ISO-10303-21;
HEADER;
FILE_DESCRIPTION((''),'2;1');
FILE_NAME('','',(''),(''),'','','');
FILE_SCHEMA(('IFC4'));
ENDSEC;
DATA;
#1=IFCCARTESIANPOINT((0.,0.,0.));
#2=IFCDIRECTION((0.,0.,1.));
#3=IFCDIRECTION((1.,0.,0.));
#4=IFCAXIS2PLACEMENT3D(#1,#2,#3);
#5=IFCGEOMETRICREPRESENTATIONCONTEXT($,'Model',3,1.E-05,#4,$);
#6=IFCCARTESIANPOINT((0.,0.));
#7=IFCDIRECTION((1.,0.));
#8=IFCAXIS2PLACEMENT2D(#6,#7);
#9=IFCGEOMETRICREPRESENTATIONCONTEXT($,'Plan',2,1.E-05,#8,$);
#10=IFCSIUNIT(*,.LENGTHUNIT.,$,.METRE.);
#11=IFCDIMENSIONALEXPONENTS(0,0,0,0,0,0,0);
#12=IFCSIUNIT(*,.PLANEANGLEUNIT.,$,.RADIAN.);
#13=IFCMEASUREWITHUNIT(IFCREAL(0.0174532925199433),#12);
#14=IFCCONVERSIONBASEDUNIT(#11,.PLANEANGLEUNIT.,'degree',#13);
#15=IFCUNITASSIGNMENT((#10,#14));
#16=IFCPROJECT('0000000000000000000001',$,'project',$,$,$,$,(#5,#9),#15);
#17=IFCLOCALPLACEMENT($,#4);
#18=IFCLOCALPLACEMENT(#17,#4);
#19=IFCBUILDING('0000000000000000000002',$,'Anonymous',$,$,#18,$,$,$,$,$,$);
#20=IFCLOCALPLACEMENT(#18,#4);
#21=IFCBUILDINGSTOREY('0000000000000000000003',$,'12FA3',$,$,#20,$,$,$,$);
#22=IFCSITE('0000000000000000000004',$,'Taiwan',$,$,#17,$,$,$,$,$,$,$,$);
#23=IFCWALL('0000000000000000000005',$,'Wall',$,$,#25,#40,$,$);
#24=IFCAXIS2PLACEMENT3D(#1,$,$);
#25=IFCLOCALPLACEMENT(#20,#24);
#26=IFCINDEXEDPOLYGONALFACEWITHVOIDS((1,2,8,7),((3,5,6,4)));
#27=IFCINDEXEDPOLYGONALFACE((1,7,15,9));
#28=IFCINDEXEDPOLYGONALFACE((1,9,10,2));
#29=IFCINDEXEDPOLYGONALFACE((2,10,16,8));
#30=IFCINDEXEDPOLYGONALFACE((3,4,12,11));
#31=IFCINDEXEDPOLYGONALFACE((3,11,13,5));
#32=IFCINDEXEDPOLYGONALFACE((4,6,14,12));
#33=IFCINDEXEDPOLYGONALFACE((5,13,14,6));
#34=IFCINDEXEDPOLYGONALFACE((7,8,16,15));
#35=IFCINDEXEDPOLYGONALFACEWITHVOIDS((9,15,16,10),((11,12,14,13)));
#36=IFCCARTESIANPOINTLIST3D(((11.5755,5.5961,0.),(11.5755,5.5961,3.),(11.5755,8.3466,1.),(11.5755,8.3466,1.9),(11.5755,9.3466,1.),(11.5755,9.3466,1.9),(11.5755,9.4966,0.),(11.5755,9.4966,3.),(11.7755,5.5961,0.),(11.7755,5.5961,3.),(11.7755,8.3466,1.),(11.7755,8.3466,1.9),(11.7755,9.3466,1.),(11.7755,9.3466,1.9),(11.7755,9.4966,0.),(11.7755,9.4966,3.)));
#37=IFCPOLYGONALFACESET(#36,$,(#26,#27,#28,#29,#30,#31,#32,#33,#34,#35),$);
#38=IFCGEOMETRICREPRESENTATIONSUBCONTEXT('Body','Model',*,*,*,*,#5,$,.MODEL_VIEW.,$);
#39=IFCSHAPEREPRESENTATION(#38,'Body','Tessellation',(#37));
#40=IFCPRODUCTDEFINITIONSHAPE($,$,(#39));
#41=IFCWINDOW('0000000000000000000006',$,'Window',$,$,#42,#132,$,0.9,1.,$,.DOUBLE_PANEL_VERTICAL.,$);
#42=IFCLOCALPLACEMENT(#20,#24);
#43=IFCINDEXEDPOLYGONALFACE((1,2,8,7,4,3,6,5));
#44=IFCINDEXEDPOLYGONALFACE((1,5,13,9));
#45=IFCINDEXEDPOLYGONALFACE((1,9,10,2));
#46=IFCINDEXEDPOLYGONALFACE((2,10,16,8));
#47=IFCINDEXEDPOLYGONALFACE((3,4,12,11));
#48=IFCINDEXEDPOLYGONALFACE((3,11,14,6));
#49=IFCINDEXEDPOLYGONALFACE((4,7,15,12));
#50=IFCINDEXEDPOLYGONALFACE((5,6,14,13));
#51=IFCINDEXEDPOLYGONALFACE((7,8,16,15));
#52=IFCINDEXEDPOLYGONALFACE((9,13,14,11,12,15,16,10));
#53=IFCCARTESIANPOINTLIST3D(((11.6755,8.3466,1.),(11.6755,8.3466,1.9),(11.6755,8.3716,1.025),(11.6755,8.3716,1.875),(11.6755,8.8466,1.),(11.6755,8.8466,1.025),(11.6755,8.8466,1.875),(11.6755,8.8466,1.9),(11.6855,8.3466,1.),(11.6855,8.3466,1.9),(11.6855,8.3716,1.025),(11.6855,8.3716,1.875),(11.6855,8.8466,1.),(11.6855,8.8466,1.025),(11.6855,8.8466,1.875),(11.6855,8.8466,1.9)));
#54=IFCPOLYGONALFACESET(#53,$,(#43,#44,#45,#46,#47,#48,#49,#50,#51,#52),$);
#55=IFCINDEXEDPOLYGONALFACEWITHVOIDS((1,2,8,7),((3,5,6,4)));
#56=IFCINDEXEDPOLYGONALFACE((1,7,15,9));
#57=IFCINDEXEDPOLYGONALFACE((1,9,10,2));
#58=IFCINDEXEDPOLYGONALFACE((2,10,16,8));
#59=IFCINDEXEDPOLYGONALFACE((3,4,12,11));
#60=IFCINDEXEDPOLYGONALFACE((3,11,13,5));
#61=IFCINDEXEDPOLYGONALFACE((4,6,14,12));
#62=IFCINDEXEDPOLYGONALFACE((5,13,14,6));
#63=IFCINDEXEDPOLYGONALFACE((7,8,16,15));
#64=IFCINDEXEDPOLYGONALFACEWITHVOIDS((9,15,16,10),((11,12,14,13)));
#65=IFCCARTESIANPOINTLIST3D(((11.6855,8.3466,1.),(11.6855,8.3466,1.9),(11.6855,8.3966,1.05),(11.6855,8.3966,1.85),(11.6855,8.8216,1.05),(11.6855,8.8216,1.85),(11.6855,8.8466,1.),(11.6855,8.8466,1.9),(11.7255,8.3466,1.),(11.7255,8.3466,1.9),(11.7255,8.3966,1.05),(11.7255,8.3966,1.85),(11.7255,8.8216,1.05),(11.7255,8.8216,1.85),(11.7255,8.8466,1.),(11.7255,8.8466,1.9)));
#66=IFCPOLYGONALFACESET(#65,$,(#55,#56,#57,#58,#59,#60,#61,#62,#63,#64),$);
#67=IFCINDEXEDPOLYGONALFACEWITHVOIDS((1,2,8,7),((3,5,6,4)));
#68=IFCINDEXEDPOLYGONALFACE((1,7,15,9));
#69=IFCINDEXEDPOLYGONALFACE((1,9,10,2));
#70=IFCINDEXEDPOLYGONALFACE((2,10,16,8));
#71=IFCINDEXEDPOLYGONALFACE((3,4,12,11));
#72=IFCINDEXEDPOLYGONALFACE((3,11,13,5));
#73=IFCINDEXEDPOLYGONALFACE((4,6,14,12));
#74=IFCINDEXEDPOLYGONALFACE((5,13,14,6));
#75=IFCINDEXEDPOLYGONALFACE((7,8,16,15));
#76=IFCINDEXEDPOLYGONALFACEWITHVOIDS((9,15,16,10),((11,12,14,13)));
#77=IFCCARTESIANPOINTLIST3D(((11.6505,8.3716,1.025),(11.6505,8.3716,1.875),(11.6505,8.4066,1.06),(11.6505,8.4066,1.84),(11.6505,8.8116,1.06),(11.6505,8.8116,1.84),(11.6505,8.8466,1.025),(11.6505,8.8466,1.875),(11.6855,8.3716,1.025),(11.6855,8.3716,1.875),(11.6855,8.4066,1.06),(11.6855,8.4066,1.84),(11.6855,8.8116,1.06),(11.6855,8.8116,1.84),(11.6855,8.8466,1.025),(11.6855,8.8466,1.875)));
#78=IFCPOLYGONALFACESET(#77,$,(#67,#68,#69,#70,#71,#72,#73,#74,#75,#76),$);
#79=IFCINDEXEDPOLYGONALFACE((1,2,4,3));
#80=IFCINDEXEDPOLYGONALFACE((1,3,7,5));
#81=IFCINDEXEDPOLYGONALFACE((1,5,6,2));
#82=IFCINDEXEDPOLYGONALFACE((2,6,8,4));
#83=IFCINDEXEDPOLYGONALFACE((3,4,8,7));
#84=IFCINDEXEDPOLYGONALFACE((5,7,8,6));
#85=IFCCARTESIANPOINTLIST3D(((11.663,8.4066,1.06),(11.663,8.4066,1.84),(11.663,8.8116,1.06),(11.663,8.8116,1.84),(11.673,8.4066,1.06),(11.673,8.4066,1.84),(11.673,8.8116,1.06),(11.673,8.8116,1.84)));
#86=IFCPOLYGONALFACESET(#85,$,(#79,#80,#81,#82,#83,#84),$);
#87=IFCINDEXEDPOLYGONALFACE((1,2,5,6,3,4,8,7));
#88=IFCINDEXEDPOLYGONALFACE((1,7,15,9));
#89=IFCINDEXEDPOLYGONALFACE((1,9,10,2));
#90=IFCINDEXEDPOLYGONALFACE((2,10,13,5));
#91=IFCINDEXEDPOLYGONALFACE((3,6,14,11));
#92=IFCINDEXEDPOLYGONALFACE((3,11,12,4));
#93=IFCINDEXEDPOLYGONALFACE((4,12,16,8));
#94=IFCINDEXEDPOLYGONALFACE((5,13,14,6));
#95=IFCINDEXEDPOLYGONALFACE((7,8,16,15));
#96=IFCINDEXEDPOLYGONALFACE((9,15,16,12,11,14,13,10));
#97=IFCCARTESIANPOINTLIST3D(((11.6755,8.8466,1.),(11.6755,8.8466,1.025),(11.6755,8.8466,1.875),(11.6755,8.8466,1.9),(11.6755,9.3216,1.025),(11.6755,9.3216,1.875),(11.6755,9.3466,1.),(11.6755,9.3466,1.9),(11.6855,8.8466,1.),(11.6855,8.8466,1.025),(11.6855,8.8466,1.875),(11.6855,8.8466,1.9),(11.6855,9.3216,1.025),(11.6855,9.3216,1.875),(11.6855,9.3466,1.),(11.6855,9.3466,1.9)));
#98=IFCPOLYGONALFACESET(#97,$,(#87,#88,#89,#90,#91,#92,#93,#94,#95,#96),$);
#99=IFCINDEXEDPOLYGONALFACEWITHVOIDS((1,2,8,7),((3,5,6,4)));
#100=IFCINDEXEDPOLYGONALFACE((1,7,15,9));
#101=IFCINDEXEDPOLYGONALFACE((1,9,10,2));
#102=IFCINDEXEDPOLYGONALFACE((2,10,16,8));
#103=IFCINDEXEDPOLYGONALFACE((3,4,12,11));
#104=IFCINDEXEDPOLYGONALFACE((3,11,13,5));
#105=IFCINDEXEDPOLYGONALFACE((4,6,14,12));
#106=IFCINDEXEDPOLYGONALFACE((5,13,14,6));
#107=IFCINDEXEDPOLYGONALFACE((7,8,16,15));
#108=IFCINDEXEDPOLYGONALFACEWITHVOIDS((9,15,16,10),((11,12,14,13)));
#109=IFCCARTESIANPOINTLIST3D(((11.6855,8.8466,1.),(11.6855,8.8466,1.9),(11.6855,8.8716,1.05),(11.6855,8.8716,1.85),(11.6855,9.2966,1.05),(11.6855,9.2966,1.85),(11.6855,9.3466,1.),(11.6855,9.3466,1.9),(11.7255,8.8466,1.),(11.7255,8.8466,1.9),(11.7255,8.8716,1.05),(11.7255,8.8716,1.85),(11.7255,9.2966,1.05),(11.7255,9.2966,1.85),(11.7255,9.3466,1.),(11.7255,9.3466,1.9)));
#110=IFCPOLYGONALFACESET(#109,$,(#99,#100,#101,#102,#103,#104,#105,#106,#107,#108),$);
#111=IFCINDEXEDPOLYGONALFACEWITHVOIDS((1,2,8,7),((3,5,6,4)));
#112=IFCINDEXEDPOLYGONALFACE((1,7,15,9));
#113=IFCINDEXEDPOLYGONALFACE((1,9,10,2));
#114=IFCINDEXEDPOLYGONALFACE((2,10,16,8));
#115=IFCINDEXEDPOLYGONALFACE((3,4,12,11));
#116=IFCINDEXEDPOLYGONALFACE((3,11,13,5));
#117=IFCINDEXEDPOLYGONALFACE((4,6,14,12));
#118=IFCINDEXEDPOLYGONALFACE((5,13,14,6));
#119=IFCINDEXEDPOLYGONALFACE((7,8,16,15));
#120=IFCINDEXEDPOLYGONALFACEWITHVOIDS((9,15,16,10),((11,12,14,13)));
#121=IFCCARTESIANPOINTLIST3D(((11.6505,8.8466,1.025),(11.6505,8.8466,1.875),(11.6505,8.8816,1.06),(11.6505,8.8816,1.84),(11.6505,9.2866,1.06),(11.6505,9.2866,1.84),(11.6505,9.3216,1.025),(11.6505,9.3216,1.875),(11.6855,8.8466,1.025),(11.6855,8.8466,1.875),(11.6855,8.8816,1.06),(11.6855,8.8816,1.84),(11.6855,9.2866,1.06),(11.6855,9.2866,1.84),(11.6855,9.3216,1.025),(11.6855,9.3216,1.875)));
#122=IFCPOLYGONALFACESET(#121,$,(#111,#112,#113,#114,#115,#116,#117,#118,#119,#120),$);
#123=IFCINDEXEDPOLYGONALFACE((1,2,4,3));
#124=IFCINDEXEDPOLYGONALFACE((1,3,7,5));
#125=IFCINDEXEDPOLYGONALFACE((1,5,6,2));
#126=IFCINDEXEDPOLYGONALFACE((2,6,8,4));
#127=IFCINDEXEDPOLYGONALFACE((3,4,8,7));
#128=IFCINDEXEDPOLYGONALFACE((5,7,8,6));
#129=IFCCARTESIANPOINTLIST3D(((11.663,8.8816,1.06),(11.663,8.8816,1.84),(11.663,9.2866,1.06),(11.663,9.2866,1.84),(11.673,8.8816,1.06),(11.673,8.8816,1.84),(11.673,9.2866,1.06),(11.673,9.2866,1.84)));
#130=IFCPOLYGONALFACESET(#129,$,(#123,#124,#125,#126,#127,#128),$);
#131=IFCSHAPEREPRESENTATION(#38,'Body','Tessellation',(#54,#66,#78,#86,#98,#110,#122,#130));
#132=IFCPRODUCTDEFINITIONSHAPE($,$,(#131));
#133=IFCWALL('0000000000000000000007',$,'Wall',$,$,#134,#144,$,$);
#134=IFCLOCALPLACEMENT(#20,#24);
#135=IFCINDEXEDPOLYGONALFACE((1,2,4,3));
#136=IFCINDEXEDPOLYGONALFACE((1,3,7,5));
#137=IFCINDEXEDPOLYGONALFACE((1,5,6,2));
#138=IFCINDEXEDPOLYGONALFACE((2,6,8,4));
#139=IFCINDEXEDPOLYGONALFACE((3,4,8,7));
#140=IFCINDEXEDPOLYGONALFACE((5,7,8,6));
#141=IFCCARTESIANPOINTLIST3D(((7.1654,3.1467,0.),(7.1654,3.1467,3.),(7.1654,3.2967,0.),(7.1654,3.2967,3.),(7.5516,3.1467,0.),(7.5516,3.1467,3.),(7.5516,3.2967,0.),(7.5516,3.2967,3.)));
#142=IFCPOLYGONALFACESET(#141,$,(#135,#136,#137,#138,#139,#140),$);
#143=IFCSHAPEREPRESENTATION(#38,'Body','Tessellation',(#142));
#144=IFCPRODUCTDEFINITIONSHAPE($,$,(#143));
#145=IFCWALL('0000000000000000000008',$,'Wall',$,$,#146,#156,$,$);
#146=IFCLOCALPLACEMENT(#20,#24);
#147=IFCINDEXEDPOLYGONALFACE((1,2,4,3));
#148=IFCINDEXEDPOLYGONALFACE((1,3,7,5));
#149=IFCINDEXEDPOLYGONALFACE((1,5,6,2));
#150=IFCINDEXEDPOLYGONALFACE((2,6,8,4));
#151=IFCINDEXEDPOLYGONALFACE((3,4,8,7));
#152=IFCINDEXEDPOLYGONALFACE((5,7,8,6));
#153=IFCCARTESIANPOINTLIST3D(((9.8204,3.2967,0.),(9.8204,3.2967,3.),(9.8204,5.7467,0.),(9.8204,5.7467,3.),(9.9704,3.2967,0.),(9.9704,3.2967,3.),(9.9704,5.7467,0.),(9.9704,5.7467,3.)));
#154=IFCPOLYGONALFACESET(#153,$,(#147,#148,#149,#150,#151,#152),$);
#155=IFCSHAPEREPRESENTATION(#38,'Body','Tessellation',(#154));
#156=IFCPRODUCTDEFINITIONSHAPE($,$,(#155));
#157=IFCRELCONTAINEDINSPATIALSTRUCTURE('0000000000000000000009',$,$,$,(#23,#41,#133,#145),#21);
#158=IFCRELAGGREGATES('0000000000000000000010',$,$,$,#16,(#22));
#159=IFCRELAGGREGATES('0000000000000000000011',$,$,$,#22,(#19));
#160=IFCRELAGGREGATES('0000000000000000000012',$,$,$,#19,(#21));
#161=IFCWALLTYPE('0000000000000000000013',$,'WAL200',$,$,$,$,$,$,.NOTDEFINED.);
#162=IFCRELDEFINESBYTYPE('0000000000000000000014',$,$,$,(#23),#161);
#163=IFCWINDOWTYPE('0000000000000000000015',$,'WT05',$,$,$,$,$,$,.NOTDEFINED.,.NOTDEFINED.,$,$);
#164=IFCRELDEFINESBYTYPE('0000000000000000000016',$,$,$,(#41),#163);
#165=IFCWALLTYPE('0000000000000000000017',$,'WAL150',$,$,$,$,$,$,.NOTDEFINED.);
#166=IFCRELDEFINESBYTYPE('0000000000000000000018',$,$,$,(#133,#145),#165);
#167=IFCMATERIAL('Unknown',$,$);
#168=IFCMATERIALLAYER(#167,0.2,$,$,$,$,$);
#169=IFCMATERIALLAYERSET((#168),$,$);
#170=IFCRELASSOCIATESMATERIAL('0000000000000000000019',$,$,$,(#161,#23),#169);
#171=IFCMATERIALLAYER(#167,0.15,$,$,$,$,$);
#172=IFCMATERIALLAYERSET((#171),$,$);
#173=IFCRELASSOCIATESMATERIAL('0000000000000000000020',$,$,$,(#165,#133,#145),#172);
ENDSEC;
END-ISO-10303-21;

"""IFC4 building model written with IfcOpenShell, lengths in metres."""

from ifc_helpers import new_model, entity, si_unit, converted_unit, frame, origin_with_axes, origin_2d_with_axis, place, context, subcontext, project, spatial, line, indexed_curve, outline, extrude, shape, source, transform, mapped, material, layer, layer_set, layer_usage, type_object, type_shapes, element, fill, save


model = new_model("IFC4")

# Units and contexts
model_context = context("Model", 3, precision=1e-05, world=origin_with_axes())
plan_context = context("Plan", 2, precision=1e-05, world=origin_2d_with_axis())
body_context_1 = subcontext(model_context, "Body", "Model", "MODEL_VIEW")
body_context_2 = subcontext(plan_context, "Body", "Plan", "PLAN_VIEW")
ifc_project = project(units=[si_unit("LENGTHUNIT", "METRE"), converted_unit("PLANEANGLEUNIT", "degree", entity("IfcReal", 0.0174532925199433), si_unit("PLANEANGLEUNIT", "RADIAN"), dimensions=[0, 0, 0, 0, 0, 0, 0])], contexts=[model_context, plan_context])

# Site, building, storey
site_placement = place(None, origin_with_axes())
site = spatial("IfcSite", under=ifc_project, at=site_placement, Name="Taiwan")
building_placement = place(site_placement, origin_with_axes())
building = spatial("IfcBuilding", under=site, at=building_placement, Name="Anonymous")
storey_placement = place(building_placement, origin_with_axes())
storey = spatial("IfcBuildingStorey", under=building, at=storey_placement, Name="12FA3")

# Shared definitions
ifc_material = material(Name="Unknown")

# Wall, opening, window
ifc_layer_1 = layer(ifc_material, 0.2)
ifc_layer_set_1 = layer_set([ifc_layer_1])
ifc_layer_usage_1 = layer_usage(ifc_layer_set_1, "AXIS2", "POSITIVE", 0.0)
wall_type_1 = type_object("IfcWallType", Name="WAL200", PredefinedType="NOTDEFINED", material=ifc_layer_set_1)
wall_1_placement = place(storey_placement, frame((11.7755, 5.5961, 0.0), z_axis=(0.0, 0.0, 1.0), x_axis=(0.0, 1.0, 0.0)))
wall_1 = element("IfcWall", 1, at=wall_1_placement, inside=storey, type_object=wall_type_1, material=ifc_layer_usage_1, Name="Wall", context=body_context_1, shape_type="SweptSolid", body=[
    extrude(outline(indexed_curve([(0.0, 0.0), (0.0, 0.2), (3.9005, 0.2), (3.9005, 0.0)], segments=[line(1, 2, 3, 4, 1)])), origin_with_axes(), (0.0, 0.0, 1.0), 3.0),
])
shared_shape_1 = source(origin_with_axes(), body_context_1, "Body", "SweptSolid", [
    extrude(outline(indexed_curve([(0.0, 0.0), (1.0, 0.0), (1.0, 0.9), (0.0, 0.9)], segments=[line(1, 2, 3, 4, 1)])), frame((0.0, -0.6, 0.0), z_axis=(0.0, -1.0, 0.0), x_axis=(1.0, 0.0, 0.0)), (0.0, 0.0, -1.0), 1.2),
])
opening_1_placement = place(wall_1_placement, frame((2.7505, 0.0, 1.0), z_axis=(0.0, 0.0, 1.0), x_axis=(1.0, 0.0, 0.0)))
opening_1 = element("IfcOpeningElement", 2, at=opening_1_placement, cuts=wall_1, PredefinedType="OPENING", context=body_context_1, shape_type="MappedRepresentation", body=[
    mapped(shared_shape_1, transform((0.0, 0.0, 0.0), x_axis=(1.0, 0.0, 0.0), y_axis=(0.0, 1.0, 0.0), z_axis=(0.0, 0.0, 1.0), scale=1.0)),
])
window_type_1 = type_object("IfcWindowType", Name="WT05", PartitioningType="NOTDEFINED", PredefinedType="NOTDEFINED")
shared_shape_2 = source(origin_with_axes(), body_context_1, "Body", "SweptSolid", [
    extrude(outline(indexed_curve([(0.5, 0.0), (0.0, 0.0), (0.0, 0.9), (0.5, 0.9), (0.5, 0.875), (0.025, 0.875), (0.025, 0.025), (0.5, 0.025)], segments=[line(1, 2, 3, 4, 5, 6, 7, 8, 1)])), frame((0.0, 0.09, 0.0), z_axis=(0.0, -1.0, 0.0), x_axis=(1.0, 0.0, 0.0)), (0.0, 0.0, -1.0), 0.01),
    extrude(outline(indexed_curve([(0.0, 0.0), (0.5, 0.0), (0.5, 0.9), (0.0, 0.9)], segments=[line(1, 2, 3, 4, 1)]), holes=[indexed_curve([(0.05, 0.05), (0.475, 0.05), (0.475, 0.85), (0.05, 0.85)], segments=[line(1, 2, 3, 4, 1)])]), frame((0.0, 0.05, 0.0), z_axis=(0.0, -1.0, 0.0), x_axis=(1.0, 0.0, 0.0)), (0.0, 0.0, -1.0), 0.04),
    extrude(outline(indexed_curve([(0.0, 0.0), (0.475, 0.0), (0.475, 0.85), (0.0, 0.85)], segments=[line(1, 2, 3, 4, 1)]), holes=[indexed_curve([(0.035, 0.035), (0.44, 0.035), (0.44, 0.815), (0.035, 0.815)], segments=[line(1, 2, 3, 4, 1)])]), frame((0.025, 0.09, 0.025), z_axis=(0.0, -1.0, 0.0), x_axis=(1.0, 0.0, 0.0)), (0.0, 0.0, -1.0), 0.035),
    extrude(outline(indexed_curve([(0.035, 0.035), (0.44, 0.035), (0.44, 0.815), (0.035, 0.815)], segments=[line(1, 2, 3, 4, 1)])), frame((0.025, 0.1025, 0.025), z_axis=(0.0, -1.0, 0.0), x_axis=(1.0, 0.0, 0.0)), (0.0, 0.0, -1.0), 0.01),
    extrude(outline(indexed_curve([(0.0, 0.9), (0.5, 0.9), (0.5, 0.0), (0.0, 0.0), (0.0, 0.025), (0.475, 0.025), (0.475, 0.875), (0.0, 0.875)], segments=[line(1, 2, 3, 4, 5, 6, 7, 8, 1)])), frame((0.5, 0.09, 0.0), z_axis=(0.0, -1.0, 0.0), x_axis=(1.0, 0.0, 0.0)), (0.0, 0.0, -1.0), 0.01),
    extrude(outline(indexed_curve([(0.0, 0.0), (0.5, 0.0), (0.5, 0.9), (0.0, 0.9)], segments=[line(1, 2, 3, 4, 1)]), holes=[indexed_curve([(0.025, 0.05), (0.45, 0.05), (0.45, 0.85), (0.025, 0.85)], segments=[line(1, 2, 3, 4, 1)])]), frame((0.5, 0.05, 0.0), z_axis=(0.0, -1.0, 0.0), x_axis=(1.0, 0.0, 0.0)), (0.0, 0.0, -1.0), 0.04),
    extrude(outline(indexed_curve([(0.0, 0.0), (0.475, 0.0), (0.475, 0.85), (0.0, 0.85)], segments=[line(1, 2, 3, 4, 1)]), holes=[indexed_curve([(0.035, 0.035), (0.44, 0.035), (0.44, 0.815), (0.035, 0.815)], segments=[line(1, 2, 3, 4, 1)])]), frame((0.5, 0.09, 0.025), z_axis=(0.0, -1.0, 0.0), x_axis=(1.0, 0.0, 0.0)), (0.0, 0.0, -1.0), 0.035),
    extrude(outline(indexed_curve([(0.035, 0.035), (0.44, 0.035), (0.44, 0.815), (0.035, 0.815)], segments=[line(1, 2, 3, 4, 1)])), frame((0.5, 0.1025, 0.025), z_axis=(0.0, -1.0, 0.0), x_axis=(1.0, 0.0, 0.0)), (0.0, 0.0, -1.0), 0.01),
])
shared_shape_3 = source(origin_with_axes(), body_context_2, "Body", "Curve2D", [
    entity("IfcIndexedPolyCurve", entity("IfcCartesianPointList2D", [[0.05, 0.05], [0.475, 0.05]])),
    entity("IfcIndexedPolyCurve", entity("IfcCartesianPointList2D", [[0.0, 0.1], [0.025, 0.1], [0.025, 0.09], [0.05, 0.09], [0.05, 0.05], [0.0, 0.05]]), [entity("IfcLineIndex", [1, 2, 3, 4, 5, 6, 1])]),
    entity("IfcIndexedPolyCurve", entity("IfcCartesianPointList2D", [[0.5, 0.1], [0.5, 0.1], [0.5, 0.09], [0.475, 0.09], [0.475, 0.05], [0.5, 0.05]])),
    entity("IfcIndexedPolyCurve", entity("IfcCartesianPointList2D", [[0.025, 0.09], [0.06, 0.09], [0.06, 0.125], [0.025, 0.125]]), [entity("IfcLineIndex", [1, 2, 3, 4, 1])]),
    entity("IfcIndexedPolyCurve", entity("IfcCartesianPointList2D", [[0.5, 0.09], [0.465, 0.09], [0.465, 0.125], [0.5, 0.125]]), [entity("IfcLineIndex", [1, 2, 3, 4, 1])]),
    entity("IfcIndexedPolyCurve", entity("IfcCartesianPointList2D", [[0.06, 0.09], [0.465, 0.09]])),
    entity("IfcIndexedPolyCurve", entity("IfcCartesianPointList2D", [[0.06, 0.125], [0.465, 0.125]])),
    entity("IfcIndexedPolyCurve", entity("IfcCartesianPointList2D", [[0.06, 0.1075], [0.465, 0.1075]])),
    entity("IfcIndexedPolyCurve", entity("IfcCartesianPointList2D", [[0.525, 0.05], [0.95, 0.05]])),
    entity("IfcIndexedPolyCurve", entity("IfcCartesianPointList2D", [[0.5, 0.1], [0.5, 0.1], [0.5, 0.09], [0.525, 0.09], [0.525, 0.05], [0.5, 0.05]])),
    entity("IfcIndexedPolyCurve", entity("IfcCartesianPointList2D", [[1.0, 0.1], [0.975, 0.1], [0.975, 0.09], [0.95, 0.09], [0.95, 0.05], [1.0, 0.05]]), [entity("IfcLineIndex", [1, 2, 3, 4, 5, 6, 1])]),
    entity("IfcIndexedPolyCurve", entity("IfcCartesianPointList2D", [[0.5, 0.09], [0.535, 0.09], [0.535, 0.125], [0.5, 0.125]]), [entity("IfcLineIndex", [1, 2, 3, 4, 1])]),
    entity("IfcIndexedPolyCurve", entity("IfcCartesianPointList2D", [[0.975, 0.09], [0.94, 0.09], [0.94, 0.125], [0.975, 0.125]]), [entity("IfcLineIndex", [1, 2, 3, 4, 1])]),
    entity("IfcIndexedPolyCurve", entity("IfcCartesianPointList2D", [[0.535, 0.09], [0.94, 0.09]])),
    entity("IfcIndexedPolyCurve", entity("IfcCartesianPointList2D", [[0.535, 0.125], [0.94, 0.125]])),
    entity("IfcIndexedPolyCurve", entity("IfcCartesianPointList2D", [[0.535, 0.1075], [0.94, 0.1075]])),
])
type_shapes(window_type_1, [shared_shape_2, shared_shape_3])
window_1_placement = place(opening_1_placement, frame((0.0, 0.0, 0.0), z_axis=(0.0, 0.0, 1.0), x_axis=(1.0, 0.0, 0.0)))
window_1 = element("IfcWindow", 3, at=window_1_placement, inside=storey, type_object=window_type_1, Name="Window", OverallHeight=0.9, OverallWidth=1.0, PartitioningType="DOUBLE_PANEL_VERTICAL", shapes=[
    shape(body_context_1, "Body", "MappedRepresentation", [mapped(shared_shape_2, transform((0.0, 0.0, 0.0), x_axis=(1.0, 0.0, 0.0), y_axis=(0.0, 1.0, 0.0), z_axis=(0.0, 0.0, 1.0), scale=1.0))]),
    shape(body_context_2, "Body", "MappedRepresentation", [mapped(shared_shape_3, transform((0.0, 0.0, 0.0), x_axis=(1.0, 0.0, 0.0), y_axis=(0.0, 1.0, 0.0), z_axis=(0.0, 0.0, 1.0), scale=1.0))]),
])
fill(opening_1, window_1)
ifc_layer_2 = layer(ifc_material, 0.15)
ifc_layer_set_2 = layer_set([ifc_layer_2])
wall_type_2 = type_object("IfcWallType", Name="WAL150", PredefinedType="NOTDEFINED", material=ifc_layer_set_2)

# Wall
ifc_layer_usage_2 = layer_usage(ifc_layer_set_2, "AXIS2", "POSITIVE", 0.0)
wall_2_placement = place(storey_placement, frame((7.1654, 3.1467, 0.0), z_axis=(0.0, 0.0, 1.0), x_axis=(1.0, 0.0, 0.0)))
element("IfcWall", 4, at=wall_2_placement, inside=storey, type_object=wall_type_2, material=ifc_layer_usage_2, Name="Wall", context=body_context_1, shape_type="SweptSolid", body=[
    extrude(outline(indexed_curve([(0.0, 0.0), (0.0, 0.15), (0.3862, 0.15), (0.3862, 0.0)], segments=[line(1, 2, 3, 4, 1)])), origin_with_axes(), (0.0, 0.0, 1.0), 3.0),
])

# Wall
ifc_layer_usage_3 = layer_usage(ifc_layer_set_2, "AXIS2", "POSITIVE", 0.0)
wall_3_placement = place(storey_placement, frame((9.9704, 3.2967, 0.0), z_axis=(0.0, 0.0, 1.0), x_axis=(0.0, 1.0, 0.0)))
element("IfcWall", 5, at=wall_3_placement, inside=storey, type_object=wall_type_2, material=ifc_layer_usage_3, Name="Wall", context=body_context_1, shape_type="SweptSolid", body=[
    extrude(outline(indexed_curve([(0.0, 0.0), (0.0, 0.15), (2.45, 0.15), (2.45, 0.0)], segments=[line(1, 2, 3, 4, 1)])), origin_with_axes(), (0.0, 0.0, 1.0), 3.0),
])

save(model, "model.ifc")
